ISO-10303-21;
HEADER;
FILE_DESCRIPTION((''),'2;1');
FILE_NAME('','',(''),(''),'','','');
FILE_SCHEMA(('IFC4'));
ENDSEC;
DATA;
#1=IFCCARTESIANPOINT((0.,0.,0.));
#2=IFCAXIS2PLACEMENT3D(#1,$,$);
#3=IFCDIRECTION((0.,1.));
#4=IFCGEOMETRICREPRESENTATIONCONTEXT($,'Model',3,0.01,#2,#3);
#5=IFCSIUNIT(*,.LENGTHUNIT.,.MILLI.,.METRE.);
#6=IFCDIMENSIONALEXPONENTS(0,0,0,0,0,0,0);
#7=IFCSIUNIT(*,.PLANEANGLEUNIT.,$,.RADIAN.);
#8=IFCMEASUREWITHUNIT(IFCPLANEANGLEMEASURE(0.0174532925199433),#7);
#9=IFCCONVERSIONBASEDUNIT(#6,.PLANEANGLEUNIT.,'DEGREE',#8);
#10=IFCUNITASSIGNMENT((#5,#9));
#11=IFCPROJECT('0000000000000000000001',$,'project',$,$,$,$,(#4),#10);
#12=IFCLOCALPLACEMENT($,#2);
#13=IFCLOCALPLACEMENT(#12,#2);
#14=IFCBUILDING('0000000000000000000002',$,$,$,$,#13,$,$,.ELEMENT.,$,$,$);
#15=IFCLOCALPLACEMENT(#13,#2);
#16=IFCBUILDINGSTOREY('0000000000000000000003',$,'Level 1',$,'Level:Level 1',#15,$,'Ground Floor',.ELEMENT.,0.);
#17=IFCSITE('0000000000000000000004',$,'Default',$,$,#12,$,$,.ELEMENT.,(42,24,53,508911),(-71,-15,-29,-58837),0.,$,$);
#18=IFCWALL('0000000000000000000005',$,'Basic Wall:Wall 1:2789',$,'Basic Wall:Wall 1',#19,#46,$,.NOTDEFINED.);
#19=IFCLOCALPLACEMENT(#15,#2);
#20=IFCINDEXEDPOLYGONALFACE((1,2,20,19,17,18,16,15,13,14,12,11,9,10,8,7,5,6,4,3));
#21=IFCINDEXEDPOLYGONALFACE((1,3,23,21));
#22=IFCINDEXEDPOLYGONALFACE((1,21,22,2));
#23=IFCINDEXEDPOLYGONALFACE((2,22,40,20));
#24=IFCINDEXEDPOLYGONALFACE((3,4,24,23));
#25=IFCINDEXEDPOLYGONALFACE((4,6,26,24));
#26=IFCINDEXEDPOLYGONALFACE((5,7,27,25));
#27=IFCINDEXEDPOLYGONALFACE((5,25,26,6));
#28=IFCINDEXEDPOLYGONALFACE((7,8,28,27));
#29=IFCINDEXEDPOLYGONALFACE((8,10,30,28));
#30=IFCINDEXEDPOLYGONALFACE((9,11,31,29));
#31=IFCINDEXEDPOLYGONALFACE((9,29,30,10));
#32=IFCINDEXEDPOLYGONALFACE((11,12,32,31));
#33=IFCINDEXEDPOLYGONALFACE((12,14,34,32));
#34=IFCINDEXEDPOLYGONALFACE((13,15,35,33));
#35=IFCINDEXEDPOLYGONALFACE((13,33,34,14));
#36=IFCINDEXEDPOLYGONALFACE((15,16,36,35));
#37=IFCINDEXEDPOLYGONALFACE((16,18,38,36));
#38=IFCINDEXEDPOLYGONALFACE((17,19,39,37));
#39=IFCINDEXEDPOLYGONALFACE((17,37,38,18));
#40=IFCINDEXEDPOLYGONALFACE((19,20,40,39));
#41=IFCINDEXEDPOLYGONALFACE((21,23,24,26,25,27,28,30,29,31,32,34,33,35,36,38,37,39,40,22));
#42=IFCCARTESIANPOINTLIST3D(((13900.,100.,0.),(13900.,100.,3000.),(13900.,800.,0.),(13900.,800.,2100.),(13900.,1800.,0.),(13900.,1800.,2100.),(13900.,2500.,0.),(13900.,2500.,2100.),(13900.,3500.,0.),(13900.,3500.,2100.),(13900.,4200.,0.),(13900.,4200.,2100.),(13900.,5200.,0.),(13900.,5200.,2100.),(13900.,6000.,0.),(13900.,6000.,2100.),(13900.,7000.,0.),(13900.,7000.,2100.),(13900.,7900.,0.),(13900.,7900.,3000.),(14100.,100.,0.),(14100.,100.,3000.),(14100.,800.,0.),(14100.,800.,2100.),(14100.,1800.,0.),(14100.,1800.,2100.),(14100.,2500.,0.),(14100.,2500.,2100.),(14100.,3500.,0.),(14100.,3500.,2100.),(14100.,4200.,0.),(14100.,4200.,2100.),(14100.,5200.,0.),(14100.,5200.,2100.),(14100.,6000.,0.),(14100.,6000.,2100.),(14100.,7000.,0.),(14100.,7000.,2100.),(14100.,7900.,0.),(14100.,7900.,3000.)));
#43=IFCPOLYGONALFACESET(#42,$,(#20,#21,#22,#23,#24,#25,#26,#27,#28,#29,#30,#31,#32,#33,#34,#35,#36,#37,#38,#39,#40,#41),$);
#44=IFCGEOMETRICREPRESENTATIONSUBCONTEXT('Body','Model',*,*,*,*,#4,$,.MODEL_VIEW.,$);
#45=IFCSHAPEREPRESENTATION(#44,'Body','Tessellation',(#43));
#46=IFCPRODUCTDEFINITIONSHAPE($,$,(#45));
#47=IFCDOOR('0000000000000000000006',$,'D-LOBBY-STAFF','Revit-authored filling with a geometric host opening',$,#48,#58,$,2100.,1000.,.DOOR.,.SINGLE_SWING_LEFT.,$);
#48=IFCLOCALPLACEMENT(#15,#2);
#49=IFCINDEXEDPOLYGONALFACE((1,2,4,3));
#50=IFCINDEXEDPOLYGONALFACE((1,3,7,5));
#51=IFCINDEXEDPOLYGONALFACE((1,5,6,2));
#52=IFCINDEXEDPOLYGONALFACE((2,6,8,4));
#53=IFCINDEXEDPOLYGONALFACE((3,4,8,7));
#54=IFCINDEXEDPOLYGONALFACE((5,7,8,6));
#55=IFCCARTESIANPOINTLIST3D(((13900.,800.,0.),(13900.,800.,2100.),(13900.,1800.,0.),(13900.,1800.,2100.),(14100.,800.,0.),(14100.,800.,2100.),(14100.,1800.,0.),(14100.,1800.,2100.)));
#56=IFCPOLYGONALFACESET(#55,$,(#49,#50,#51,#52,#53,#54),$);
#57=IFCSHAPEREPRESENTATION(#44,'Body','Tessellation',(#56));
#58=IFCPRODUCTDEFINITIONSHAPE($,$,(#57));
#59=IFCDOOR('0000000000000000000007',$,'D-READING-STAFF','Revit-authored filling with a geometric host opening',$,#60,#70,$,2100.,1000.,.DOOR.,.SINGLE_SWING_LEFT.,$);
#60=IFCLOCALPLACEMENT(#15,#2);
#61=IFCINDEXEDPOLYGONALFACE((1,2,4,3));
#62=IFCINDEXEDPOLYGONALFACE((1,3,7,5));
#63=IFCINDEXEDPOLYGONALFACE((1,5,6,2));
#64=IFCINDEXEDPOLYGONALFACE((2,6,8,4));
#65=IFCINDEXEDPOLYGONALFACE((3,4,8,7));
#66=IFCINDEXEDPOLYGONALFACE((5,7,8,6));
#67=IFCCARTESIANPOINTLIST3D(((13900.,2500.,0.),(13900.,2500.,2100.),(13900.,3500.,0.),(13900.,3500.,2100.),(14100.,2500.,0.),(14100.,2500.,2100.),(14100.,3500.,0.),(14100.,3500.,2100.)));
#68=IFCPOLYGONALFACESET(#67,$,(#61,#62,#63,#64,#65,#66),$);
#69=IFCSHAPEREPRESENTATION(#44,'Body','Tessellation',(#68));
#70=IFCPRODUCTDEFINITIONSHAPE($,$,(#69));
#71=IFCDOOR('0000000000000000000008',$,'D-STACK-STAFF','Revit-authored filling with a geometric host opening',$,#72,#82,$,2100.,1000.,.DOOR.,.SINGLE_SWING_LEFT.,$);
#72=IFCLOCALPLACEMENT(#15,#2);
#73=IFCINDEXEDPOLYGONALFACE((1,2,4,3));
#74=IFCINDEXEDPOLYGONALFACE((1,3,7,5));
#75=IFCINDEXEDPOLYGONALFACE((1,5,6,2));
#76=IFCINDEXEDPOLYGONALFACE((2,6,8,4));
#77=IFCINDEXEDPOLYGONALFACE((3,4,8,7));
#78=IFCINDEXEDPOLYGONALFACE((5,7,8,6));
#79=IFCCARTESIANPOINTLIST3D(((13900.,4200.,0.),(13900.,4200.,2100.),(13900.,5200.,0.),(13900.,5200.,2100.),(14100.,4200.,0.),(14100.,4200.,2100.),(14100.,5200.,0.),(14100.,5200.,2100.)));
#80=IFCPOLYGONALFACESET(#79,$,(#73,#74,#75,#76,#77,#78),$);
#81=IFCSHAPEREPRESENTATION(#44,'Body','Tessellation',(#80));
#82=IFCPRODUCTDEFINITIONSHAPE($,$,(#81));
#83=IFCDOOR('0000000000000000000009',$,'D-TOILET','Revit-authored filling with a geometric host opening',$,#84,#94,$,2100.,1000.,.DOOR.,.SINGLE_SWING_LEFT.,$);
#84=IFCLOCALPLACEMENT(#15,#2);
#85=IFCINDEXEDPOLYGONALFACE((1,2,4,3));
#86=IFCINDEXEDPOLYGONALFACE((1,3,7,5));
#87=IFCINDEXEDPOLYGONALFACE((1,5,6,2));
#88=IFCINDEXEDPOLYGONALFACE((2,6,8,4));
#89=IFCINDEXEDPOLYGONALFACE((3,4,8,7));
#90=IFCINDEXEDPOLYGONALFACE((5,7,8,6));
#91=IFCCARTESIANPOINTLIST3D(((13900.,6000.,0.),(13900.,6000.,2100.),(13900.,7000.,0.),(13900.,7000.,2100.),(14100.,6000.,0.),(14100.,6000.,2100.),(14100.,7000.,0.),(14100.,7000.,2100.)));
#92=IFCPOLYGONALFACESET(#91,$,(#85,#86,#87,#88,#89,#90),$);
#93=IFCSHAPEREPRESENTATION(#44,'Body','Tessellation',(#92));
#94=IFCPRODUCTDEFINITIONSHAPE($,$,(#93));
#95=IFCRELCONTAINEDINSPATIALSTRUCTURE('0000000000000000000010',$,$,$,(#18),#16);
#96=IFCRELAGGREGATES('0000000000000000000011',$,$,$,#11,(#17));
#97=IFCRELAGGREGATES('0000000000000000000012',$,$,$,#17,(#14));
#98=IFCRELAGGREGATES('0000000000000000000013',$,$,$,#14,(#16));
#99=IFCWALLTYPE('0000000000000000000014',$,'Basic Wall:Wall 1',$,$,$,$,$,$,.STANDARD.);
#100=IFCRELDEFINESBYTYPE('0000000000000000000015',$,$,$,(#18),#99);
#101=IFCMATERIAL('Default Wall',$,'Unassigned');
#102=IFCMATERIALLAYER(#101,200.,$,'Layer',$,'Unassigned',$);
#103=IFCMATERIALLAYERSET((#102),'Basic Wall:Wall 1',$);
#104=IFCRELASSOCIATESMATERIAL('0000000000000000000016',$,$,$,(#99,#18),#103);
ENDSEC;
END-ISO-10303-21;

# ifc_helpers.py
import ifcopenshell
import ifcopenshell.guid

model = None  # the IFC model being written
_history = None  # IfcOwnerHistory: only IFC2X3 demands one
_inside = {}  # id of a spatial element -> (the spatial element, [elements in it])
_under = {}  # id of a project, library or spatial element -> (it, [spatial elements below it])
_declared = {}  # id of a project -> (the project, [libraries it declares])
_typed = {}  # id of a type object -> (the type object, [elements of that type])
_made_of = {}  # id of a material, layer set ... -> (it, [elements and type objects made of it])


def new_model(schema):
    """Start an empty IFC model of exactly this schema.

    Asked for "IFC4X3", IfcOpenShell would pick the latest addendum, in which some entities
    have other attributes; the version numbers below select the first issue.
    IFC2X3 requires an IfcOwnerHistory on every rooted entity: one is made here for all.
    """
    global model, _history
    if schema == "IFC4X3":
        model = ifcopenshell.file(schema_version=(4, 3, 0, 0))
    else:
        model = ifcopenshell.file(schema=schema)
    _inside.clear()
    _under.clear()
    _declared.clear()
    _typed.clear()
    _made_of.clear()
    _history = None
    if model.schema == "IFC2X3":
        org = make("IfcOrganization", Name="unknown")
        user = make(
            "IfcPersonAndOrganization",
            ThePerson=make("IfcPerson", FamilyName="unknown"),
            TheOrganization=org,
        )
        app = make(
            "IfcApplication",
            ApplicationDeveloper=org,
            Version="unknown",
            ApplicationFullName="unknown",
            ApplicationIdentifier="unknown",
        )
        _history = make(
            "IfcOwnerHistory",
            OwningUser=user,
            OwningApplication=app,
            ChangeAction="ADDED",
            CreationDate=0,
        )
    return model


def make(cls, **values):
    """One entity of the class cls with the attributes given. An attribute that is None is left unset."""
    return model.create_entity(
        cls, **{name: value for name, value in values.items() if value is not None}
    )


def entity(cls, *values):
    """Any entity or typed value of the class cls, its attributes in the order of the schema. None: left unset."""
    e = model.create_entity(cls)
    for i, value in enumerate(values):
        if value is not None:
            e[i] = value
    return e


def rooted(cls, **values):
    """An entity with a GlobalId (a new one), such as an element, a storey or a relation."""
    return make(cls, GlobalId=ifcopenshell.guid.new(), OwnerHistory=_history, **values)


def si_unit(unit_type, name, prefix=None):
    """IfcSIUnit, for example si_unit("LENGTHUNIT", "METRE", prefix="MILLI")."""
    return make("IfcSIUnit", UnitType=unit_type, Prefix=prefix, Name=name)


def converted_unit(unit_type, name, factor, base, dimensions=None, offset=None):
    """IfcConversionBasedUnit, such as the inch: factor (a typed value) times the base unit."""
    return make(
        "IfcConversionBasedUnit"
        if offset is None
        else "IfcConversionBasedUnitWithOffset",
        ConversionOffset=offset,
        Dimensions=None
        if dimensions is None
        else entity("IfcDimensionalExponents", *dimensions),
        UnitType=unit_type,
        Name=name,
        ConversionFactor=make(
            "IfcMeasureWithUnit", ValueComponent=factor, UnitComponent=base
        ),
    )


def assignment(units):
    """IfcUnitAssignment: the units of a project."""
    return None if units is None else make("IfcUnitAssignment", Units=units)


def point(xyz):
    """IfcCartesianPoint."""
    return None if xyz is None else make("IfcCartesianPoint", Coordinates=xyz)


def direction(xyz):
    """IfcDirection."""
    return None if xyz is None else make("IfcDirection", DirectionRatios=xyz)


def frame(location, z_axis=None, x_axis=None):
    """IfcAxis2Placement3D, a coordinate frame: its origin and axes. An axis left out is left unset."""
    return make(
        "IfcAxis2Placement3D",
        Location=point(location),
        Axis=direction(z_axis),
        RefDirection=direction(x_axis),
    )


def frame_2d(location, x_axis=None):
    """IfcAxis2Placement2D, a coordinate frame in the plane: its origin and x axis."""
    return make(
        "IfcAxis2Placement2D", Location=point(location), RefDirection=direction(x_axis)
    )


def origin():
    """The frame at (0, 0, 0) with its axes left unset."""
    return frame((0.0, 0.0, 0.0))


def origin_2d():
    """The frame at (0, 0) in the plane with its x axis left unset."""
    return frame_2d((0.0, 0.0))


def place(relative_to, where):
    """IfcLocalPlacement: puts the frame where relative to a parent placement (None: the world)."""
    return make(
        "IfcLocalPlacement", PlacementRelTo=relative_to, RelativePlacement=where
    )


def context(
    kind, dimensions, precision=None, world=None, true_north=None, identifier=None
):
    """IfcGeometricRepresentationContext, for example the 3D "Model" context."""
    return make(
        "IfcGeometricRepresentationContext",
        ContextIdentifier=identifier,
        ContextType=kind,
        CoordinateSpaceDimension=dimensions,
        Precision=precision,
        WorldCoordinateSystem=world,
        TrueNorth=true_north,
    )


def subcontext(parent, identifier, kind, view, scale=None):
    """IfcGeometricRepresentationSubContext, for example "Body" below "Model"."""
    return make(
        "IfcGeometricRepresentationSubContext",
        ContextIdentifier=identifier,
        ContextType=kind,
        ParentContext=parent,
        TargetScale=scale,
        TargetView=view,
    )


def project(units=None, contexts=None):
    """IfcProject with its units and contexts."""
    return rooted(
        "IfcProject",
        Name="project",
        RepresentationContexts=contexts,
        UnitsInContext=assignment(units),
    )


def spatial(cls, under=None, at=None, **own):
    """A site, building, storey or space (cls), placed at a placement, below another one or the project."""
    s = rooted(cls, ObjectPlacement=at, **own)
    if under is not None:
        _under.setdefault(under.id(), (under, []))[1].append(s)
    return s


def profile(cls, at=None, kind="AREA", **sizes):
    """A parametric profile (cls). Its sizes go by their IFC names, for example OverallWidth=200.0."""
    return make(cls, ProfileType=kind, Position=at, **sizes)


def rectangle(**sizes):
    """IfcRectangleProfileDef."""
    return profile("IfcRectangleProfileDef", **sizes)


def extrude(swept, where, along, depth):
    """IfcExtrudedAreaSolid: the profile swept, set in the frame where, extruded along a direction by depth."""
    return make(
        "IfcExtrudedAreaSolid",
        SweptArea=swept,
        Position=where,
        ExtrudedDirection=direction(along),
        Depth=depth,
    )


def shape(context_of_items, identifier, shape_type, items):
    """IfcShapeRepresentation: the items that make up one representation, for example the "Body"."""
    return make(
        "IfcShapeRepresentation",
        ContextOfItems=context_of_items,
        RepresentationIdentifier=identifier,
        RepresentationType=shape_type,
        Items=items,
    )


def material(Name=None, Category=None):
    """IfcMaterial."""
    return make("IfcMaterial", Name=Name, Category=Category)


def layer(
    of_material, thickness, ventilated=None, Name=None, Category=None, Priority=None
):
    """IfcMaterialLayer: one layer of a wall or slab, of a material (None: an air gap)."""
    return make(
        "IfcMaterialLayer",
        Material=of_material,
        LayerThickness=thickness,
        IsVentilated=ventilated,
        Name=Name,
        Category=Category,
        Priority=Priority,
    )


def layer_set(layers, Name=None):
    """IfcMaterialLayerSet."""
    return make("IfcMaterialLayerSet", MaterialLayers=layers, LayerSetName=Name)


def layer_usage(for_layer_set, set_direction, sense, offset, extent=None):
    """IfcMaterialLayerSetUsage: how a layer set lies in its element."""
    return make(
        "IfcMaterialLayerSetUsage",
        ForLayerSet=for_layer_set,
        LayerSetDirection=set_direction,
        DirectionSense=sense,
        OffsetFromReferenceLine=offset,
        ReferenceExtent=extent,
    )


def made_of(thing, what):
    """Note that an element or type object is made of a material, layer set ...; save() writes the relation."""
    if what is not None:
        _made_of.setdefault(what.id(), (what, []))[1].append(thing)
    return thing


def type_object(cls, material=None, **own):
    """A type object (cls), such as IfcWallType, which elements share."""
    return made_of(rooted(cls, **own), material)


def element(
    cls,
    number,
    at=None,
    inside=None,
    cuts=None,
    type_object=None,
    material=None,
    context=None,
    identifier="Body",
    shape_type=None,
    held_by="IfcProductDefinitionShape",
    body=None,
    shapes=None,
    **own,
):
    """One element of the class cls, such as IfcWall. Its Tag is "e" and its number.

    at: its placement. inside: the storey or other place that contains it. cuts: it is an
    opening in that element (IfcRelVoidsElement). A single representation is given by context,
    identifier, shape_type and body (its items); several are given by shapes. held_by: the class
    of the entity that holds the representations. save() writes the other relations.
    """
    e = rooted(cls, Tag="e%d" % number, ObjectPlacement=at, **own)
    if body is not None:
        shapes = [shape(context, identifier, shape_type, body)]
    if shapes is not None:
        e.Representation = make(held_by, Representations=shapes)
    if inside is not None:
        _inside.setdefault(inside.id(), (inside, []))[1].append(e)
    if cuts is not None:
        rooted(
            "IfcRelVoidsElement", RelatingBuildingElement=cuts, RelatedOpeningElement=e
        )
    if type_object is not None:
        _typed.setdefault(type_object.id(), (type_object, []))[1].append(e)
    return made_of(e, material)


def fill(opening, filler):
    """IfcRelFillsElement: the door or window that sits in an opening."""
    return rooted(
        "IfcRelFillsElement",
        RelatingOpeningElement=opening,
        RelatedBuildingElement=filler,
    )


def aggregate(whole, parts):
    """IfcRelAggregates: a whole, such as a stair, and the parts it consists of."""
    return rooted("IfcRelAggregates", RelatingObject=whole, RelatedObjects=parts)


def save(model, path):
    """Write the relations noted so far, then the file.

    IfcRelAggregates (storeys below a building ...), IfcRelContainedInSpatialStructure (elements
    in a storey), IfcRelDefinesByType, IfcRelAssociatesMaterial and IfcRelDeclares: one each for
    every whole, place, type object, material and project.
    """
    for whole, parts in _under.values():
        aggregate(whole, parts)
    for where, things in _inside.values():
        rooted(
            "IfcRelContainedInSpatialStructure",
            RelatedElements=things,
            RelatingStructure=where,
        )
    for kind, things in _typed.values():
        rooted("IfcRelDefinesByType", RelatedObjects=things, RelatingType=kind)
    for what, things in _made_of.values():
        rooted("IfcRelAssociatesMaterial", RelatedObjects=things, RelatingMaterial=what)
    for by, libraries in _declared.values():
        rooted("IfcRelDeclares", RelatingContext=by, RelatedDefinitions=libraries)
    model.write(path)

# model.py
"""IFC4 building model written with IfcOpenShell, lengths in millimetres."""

from ifc_helpers import new_model, entity, si_unit, converted_unit, direction, frame, frame_2d, origin, origin_2d, place, context, subcontext, project, spatial, rectangle, extrude, material, layer, layer_set, layer_usage, type_object, element, fill, save


model = new_model("IFC4")

# Units and contexts
model_context = context("Model", 3, precision=0.01, world=origin(), true_north=direction((0.0, 1.0)))
body_context = subcontext(model_context, "Body", "Model", "MODEL_VIEW")
ifc_project = project(units=[si_unit("LENGTHUNIT", "METRE", prefix="MILLI"), converted_unit("PLANEANGLEUNIT", "DEGREE", entity("IfcPlaneAngleMeasure", 0.0174532925199433), si_unit("PLANEANGLEUNIT", "RADIAN"), dimensions=[0, 0, 0, 0, 0, 0, 0])], contexts=[model_context])

# Site, building, storey
site_placement = place(None, origin())
site = spatial("IfcSite", under=ifc_project, at=site_placement, Name="Default", CompositionType="ELEMENT", RefLatitude=(42, 24, 53, 508911), RefLongitude=(-71, -15, -29, -58837), RefElevation=0.0)
building_placement = place(site_placement, origin())
building = spatial("IfcBuilding", under=site, at=building_placement, CompositionType="ELEMENT")
storey_placement = place(building_placement, origin())
storey = spatial("IfcBuildingStorey", under=building, at=storey_placement, Name="Level 1", ObjectType="Level:Level 1", LongName="Ground Floor", CompositionType="ELEMENT", Elevation=0.0)

# Shared definitions
ifc_material_1 = material(Name="Default Wall", Category="Unassigned")
ifc_layer_1 = layer(ifc_material_1, 200.0, Name="Layer", Category="Unassigned")
ifc_layer_set_1 = layer_set([ifc_layer_1], Name="Basic Wall:Wall 1")
wall_type = type_object("IfcWallType", Name="Basic Wall:Wall 1", PredefinedType="STANDARD", material=ifc_layer_set_1)

# Wall, openings, doors
ifc_layer_usage_1 = layer_usage(ifc_layer_set_1, "AXIS2", "NEGATIVE", 100.0)
wall_1_placement = place(storey_placement, frame((14000.0, 100.0, 0.0), z_axis=(0.0, 0.0, 1.0), x_axis=(0.0, 1.0, 0.0)))
wall_1 = element("IfcWall", 1, at=wall_1_placement, inside=storey, type_object=wall_type, material=ifc_layer_usage_1, Name="Basic Wall:Wall 1:2789", ObjectType="Basic Wall:Wall 1", PredefinedType="NOTDEFINED", context=body_context, shape_type="SweptSolid", body=[
    extrude(rectangle(XDim=7800.0, YDim=200.0, at=frame_2d((3900.0, 0.0), x_axis=(-1.0, 0.0))), origin(), (0.0, 0.0, 1.0), 3000.0),
])
opening_1_placement = place(storey_placement, frame((13900.0, 800.0, 0.0)))
opening_1 = element("IfcOpeningElement", 2, at=opening_1_placement, cuts=wall_1, PredefinedType="OPENING", context=body_context, shape_type="SweptSolid", body=[
    extrude(rectangle(XDim=200.0, YDim=1000.0, at=origin_2d()), frame((100.0, 500.0, 0.0)), (0.0, 0.0, 1.0), 2100.0),
])
opening_2_placement = place(storey_placement, frame((13900.0, 2500.0, 0.0)))
opening_2 = element("IfcOpeningElement", 3, at=opening_2_placement, cuts=wall_1, PredefinedType="OPENING", context=body_context, shape_type="SweptSolid", body=[
    extrude(rectangle(XDim=200.0, YDim=1000.0, at=origin_2d()), frame((100.0, 500.0, 0.0)), (0.0, 0.0, 1.0), 2100.0),
])
opening_3_placement = place(storey_placement, frame((13900.0, 4200.0, 0.0)))
opening_3 = element("IfcOpeningElement", 4, at=opening_3_placement, cuts=wall_1, PredefinedType="OPENING", context=body_context, shape_type="SweptSolid", body=[
    extrude(rectangle(XDim=200.0, YDim=1000.0, at=origin_2d()), frame((100.0, 500.0, 0.0)), (0.0, 0.0, 1.0), 2100.0),
])
opening_4_placement = place(storey_placement, frame((13900.0, 6000.0, 0.0)))
opening_4 = element("IfcOpeningElement", 5, at=opening_4_placement, cuts=wall_1, PredefinedType="OPENING", context=body_context, shape_type="SweptSolid", body=[
    extrude(rectangle(XDim=200.0, YDim=1000.0, at=origin_2d()), frame((100.0, 500.0, 0.0)), (0.0, 0.0, 1.0), 2100.0),
])
door_1_placement = place(storey_placement, frame((13900.0, 800.0, 0.0)))
door_1 = element("IfcDoor", 6, at=door_1_placement, Name="D-LOBBY-STAFF", Description="Revit-authored filling with a geometric host opening", OperationType="SINGLE_SWING_LEFT", OverallHeight=2100.0, OverallWidth=1000.0, PredefinedType="DOOR", context=body_context, shape_type="SweptSolid", body=[
    extrude(rectangle(XDim=200.0, YDim=1000.0, at=origin_2d()), frame((100.0, 500.0, 0.0)), (0.0, 0.0, 1.0), 2100.0),
])
fill(opening_1, door_1)
door_2_placement = place(storey_placement, frame((13900.0, 2500.0, 0.0)))
door_2 = element("IfcDoor", 7, at=door_2_placement, Name="D-READING-STAFF", Description="Revit-authored filling with a geometric host opening", OperationType="SINGLE_SWING_LEFT", OverallHeight=2100.0, OverallWidth=1000.0, PredefinedType="DOOR", context=body_context, shape_type="SweptSolid", body=[
    extrude(rectangle(XDim=200.0, YDim=1000.0, at=origin_2d()), frame((100.0, 500.0, 0.0)), (0.0, 0.0, 1.0), 2100.0),
])
fill(opening_2, door_2)
door_3_placement = place(storey_placement, frame((13900.0, 4200.0, 0.0)))
door_3 = element("IfcDoor", 8, at=door_3_placement, Name="D-STACK-STAFF", Description="Revit-authored filling with a geometric host opening", OperationType="SINGLE_SWING_LEFT", OverallHeight=2100.0, OverallWidth=1000.0, PredefinedType="DOOR", context=body_context, shape_type="SweptSolid", body=[
    extrude(rectangle(XDim=200.0, YDim=1000.0, at=origin_2d()), frame((100.0, 500.0, 0.0)), (0.0, 0.0, 1.0), 2100.0),
])
fill(opening_3, door_3)
door_4_placement = place(storey_placement, frame((13900.0, 6000.0, 0.0)))
door_4 = element("IfcDoor", 9, at=door_4_placement, Name="D-TOILET", Description="Revit-authored filling with a geometric host opening", OperationType="SINGLE_SWING_LEFT", OverallHeight=2100.0, OverallWidth=1000.0, PredefinedType="DOOR", context=body_context, shape_type="SweptSolid", body=[
    extrude(rectangle(XDim=200.0, YDim=1000.0, at=origin_2d()), frame((100.0, 500.0, 0.0)), (0.0, 0.0, 1.0), 2100.0),
])
fill(opening_4, door_4)

save(model, "model.ifc")
